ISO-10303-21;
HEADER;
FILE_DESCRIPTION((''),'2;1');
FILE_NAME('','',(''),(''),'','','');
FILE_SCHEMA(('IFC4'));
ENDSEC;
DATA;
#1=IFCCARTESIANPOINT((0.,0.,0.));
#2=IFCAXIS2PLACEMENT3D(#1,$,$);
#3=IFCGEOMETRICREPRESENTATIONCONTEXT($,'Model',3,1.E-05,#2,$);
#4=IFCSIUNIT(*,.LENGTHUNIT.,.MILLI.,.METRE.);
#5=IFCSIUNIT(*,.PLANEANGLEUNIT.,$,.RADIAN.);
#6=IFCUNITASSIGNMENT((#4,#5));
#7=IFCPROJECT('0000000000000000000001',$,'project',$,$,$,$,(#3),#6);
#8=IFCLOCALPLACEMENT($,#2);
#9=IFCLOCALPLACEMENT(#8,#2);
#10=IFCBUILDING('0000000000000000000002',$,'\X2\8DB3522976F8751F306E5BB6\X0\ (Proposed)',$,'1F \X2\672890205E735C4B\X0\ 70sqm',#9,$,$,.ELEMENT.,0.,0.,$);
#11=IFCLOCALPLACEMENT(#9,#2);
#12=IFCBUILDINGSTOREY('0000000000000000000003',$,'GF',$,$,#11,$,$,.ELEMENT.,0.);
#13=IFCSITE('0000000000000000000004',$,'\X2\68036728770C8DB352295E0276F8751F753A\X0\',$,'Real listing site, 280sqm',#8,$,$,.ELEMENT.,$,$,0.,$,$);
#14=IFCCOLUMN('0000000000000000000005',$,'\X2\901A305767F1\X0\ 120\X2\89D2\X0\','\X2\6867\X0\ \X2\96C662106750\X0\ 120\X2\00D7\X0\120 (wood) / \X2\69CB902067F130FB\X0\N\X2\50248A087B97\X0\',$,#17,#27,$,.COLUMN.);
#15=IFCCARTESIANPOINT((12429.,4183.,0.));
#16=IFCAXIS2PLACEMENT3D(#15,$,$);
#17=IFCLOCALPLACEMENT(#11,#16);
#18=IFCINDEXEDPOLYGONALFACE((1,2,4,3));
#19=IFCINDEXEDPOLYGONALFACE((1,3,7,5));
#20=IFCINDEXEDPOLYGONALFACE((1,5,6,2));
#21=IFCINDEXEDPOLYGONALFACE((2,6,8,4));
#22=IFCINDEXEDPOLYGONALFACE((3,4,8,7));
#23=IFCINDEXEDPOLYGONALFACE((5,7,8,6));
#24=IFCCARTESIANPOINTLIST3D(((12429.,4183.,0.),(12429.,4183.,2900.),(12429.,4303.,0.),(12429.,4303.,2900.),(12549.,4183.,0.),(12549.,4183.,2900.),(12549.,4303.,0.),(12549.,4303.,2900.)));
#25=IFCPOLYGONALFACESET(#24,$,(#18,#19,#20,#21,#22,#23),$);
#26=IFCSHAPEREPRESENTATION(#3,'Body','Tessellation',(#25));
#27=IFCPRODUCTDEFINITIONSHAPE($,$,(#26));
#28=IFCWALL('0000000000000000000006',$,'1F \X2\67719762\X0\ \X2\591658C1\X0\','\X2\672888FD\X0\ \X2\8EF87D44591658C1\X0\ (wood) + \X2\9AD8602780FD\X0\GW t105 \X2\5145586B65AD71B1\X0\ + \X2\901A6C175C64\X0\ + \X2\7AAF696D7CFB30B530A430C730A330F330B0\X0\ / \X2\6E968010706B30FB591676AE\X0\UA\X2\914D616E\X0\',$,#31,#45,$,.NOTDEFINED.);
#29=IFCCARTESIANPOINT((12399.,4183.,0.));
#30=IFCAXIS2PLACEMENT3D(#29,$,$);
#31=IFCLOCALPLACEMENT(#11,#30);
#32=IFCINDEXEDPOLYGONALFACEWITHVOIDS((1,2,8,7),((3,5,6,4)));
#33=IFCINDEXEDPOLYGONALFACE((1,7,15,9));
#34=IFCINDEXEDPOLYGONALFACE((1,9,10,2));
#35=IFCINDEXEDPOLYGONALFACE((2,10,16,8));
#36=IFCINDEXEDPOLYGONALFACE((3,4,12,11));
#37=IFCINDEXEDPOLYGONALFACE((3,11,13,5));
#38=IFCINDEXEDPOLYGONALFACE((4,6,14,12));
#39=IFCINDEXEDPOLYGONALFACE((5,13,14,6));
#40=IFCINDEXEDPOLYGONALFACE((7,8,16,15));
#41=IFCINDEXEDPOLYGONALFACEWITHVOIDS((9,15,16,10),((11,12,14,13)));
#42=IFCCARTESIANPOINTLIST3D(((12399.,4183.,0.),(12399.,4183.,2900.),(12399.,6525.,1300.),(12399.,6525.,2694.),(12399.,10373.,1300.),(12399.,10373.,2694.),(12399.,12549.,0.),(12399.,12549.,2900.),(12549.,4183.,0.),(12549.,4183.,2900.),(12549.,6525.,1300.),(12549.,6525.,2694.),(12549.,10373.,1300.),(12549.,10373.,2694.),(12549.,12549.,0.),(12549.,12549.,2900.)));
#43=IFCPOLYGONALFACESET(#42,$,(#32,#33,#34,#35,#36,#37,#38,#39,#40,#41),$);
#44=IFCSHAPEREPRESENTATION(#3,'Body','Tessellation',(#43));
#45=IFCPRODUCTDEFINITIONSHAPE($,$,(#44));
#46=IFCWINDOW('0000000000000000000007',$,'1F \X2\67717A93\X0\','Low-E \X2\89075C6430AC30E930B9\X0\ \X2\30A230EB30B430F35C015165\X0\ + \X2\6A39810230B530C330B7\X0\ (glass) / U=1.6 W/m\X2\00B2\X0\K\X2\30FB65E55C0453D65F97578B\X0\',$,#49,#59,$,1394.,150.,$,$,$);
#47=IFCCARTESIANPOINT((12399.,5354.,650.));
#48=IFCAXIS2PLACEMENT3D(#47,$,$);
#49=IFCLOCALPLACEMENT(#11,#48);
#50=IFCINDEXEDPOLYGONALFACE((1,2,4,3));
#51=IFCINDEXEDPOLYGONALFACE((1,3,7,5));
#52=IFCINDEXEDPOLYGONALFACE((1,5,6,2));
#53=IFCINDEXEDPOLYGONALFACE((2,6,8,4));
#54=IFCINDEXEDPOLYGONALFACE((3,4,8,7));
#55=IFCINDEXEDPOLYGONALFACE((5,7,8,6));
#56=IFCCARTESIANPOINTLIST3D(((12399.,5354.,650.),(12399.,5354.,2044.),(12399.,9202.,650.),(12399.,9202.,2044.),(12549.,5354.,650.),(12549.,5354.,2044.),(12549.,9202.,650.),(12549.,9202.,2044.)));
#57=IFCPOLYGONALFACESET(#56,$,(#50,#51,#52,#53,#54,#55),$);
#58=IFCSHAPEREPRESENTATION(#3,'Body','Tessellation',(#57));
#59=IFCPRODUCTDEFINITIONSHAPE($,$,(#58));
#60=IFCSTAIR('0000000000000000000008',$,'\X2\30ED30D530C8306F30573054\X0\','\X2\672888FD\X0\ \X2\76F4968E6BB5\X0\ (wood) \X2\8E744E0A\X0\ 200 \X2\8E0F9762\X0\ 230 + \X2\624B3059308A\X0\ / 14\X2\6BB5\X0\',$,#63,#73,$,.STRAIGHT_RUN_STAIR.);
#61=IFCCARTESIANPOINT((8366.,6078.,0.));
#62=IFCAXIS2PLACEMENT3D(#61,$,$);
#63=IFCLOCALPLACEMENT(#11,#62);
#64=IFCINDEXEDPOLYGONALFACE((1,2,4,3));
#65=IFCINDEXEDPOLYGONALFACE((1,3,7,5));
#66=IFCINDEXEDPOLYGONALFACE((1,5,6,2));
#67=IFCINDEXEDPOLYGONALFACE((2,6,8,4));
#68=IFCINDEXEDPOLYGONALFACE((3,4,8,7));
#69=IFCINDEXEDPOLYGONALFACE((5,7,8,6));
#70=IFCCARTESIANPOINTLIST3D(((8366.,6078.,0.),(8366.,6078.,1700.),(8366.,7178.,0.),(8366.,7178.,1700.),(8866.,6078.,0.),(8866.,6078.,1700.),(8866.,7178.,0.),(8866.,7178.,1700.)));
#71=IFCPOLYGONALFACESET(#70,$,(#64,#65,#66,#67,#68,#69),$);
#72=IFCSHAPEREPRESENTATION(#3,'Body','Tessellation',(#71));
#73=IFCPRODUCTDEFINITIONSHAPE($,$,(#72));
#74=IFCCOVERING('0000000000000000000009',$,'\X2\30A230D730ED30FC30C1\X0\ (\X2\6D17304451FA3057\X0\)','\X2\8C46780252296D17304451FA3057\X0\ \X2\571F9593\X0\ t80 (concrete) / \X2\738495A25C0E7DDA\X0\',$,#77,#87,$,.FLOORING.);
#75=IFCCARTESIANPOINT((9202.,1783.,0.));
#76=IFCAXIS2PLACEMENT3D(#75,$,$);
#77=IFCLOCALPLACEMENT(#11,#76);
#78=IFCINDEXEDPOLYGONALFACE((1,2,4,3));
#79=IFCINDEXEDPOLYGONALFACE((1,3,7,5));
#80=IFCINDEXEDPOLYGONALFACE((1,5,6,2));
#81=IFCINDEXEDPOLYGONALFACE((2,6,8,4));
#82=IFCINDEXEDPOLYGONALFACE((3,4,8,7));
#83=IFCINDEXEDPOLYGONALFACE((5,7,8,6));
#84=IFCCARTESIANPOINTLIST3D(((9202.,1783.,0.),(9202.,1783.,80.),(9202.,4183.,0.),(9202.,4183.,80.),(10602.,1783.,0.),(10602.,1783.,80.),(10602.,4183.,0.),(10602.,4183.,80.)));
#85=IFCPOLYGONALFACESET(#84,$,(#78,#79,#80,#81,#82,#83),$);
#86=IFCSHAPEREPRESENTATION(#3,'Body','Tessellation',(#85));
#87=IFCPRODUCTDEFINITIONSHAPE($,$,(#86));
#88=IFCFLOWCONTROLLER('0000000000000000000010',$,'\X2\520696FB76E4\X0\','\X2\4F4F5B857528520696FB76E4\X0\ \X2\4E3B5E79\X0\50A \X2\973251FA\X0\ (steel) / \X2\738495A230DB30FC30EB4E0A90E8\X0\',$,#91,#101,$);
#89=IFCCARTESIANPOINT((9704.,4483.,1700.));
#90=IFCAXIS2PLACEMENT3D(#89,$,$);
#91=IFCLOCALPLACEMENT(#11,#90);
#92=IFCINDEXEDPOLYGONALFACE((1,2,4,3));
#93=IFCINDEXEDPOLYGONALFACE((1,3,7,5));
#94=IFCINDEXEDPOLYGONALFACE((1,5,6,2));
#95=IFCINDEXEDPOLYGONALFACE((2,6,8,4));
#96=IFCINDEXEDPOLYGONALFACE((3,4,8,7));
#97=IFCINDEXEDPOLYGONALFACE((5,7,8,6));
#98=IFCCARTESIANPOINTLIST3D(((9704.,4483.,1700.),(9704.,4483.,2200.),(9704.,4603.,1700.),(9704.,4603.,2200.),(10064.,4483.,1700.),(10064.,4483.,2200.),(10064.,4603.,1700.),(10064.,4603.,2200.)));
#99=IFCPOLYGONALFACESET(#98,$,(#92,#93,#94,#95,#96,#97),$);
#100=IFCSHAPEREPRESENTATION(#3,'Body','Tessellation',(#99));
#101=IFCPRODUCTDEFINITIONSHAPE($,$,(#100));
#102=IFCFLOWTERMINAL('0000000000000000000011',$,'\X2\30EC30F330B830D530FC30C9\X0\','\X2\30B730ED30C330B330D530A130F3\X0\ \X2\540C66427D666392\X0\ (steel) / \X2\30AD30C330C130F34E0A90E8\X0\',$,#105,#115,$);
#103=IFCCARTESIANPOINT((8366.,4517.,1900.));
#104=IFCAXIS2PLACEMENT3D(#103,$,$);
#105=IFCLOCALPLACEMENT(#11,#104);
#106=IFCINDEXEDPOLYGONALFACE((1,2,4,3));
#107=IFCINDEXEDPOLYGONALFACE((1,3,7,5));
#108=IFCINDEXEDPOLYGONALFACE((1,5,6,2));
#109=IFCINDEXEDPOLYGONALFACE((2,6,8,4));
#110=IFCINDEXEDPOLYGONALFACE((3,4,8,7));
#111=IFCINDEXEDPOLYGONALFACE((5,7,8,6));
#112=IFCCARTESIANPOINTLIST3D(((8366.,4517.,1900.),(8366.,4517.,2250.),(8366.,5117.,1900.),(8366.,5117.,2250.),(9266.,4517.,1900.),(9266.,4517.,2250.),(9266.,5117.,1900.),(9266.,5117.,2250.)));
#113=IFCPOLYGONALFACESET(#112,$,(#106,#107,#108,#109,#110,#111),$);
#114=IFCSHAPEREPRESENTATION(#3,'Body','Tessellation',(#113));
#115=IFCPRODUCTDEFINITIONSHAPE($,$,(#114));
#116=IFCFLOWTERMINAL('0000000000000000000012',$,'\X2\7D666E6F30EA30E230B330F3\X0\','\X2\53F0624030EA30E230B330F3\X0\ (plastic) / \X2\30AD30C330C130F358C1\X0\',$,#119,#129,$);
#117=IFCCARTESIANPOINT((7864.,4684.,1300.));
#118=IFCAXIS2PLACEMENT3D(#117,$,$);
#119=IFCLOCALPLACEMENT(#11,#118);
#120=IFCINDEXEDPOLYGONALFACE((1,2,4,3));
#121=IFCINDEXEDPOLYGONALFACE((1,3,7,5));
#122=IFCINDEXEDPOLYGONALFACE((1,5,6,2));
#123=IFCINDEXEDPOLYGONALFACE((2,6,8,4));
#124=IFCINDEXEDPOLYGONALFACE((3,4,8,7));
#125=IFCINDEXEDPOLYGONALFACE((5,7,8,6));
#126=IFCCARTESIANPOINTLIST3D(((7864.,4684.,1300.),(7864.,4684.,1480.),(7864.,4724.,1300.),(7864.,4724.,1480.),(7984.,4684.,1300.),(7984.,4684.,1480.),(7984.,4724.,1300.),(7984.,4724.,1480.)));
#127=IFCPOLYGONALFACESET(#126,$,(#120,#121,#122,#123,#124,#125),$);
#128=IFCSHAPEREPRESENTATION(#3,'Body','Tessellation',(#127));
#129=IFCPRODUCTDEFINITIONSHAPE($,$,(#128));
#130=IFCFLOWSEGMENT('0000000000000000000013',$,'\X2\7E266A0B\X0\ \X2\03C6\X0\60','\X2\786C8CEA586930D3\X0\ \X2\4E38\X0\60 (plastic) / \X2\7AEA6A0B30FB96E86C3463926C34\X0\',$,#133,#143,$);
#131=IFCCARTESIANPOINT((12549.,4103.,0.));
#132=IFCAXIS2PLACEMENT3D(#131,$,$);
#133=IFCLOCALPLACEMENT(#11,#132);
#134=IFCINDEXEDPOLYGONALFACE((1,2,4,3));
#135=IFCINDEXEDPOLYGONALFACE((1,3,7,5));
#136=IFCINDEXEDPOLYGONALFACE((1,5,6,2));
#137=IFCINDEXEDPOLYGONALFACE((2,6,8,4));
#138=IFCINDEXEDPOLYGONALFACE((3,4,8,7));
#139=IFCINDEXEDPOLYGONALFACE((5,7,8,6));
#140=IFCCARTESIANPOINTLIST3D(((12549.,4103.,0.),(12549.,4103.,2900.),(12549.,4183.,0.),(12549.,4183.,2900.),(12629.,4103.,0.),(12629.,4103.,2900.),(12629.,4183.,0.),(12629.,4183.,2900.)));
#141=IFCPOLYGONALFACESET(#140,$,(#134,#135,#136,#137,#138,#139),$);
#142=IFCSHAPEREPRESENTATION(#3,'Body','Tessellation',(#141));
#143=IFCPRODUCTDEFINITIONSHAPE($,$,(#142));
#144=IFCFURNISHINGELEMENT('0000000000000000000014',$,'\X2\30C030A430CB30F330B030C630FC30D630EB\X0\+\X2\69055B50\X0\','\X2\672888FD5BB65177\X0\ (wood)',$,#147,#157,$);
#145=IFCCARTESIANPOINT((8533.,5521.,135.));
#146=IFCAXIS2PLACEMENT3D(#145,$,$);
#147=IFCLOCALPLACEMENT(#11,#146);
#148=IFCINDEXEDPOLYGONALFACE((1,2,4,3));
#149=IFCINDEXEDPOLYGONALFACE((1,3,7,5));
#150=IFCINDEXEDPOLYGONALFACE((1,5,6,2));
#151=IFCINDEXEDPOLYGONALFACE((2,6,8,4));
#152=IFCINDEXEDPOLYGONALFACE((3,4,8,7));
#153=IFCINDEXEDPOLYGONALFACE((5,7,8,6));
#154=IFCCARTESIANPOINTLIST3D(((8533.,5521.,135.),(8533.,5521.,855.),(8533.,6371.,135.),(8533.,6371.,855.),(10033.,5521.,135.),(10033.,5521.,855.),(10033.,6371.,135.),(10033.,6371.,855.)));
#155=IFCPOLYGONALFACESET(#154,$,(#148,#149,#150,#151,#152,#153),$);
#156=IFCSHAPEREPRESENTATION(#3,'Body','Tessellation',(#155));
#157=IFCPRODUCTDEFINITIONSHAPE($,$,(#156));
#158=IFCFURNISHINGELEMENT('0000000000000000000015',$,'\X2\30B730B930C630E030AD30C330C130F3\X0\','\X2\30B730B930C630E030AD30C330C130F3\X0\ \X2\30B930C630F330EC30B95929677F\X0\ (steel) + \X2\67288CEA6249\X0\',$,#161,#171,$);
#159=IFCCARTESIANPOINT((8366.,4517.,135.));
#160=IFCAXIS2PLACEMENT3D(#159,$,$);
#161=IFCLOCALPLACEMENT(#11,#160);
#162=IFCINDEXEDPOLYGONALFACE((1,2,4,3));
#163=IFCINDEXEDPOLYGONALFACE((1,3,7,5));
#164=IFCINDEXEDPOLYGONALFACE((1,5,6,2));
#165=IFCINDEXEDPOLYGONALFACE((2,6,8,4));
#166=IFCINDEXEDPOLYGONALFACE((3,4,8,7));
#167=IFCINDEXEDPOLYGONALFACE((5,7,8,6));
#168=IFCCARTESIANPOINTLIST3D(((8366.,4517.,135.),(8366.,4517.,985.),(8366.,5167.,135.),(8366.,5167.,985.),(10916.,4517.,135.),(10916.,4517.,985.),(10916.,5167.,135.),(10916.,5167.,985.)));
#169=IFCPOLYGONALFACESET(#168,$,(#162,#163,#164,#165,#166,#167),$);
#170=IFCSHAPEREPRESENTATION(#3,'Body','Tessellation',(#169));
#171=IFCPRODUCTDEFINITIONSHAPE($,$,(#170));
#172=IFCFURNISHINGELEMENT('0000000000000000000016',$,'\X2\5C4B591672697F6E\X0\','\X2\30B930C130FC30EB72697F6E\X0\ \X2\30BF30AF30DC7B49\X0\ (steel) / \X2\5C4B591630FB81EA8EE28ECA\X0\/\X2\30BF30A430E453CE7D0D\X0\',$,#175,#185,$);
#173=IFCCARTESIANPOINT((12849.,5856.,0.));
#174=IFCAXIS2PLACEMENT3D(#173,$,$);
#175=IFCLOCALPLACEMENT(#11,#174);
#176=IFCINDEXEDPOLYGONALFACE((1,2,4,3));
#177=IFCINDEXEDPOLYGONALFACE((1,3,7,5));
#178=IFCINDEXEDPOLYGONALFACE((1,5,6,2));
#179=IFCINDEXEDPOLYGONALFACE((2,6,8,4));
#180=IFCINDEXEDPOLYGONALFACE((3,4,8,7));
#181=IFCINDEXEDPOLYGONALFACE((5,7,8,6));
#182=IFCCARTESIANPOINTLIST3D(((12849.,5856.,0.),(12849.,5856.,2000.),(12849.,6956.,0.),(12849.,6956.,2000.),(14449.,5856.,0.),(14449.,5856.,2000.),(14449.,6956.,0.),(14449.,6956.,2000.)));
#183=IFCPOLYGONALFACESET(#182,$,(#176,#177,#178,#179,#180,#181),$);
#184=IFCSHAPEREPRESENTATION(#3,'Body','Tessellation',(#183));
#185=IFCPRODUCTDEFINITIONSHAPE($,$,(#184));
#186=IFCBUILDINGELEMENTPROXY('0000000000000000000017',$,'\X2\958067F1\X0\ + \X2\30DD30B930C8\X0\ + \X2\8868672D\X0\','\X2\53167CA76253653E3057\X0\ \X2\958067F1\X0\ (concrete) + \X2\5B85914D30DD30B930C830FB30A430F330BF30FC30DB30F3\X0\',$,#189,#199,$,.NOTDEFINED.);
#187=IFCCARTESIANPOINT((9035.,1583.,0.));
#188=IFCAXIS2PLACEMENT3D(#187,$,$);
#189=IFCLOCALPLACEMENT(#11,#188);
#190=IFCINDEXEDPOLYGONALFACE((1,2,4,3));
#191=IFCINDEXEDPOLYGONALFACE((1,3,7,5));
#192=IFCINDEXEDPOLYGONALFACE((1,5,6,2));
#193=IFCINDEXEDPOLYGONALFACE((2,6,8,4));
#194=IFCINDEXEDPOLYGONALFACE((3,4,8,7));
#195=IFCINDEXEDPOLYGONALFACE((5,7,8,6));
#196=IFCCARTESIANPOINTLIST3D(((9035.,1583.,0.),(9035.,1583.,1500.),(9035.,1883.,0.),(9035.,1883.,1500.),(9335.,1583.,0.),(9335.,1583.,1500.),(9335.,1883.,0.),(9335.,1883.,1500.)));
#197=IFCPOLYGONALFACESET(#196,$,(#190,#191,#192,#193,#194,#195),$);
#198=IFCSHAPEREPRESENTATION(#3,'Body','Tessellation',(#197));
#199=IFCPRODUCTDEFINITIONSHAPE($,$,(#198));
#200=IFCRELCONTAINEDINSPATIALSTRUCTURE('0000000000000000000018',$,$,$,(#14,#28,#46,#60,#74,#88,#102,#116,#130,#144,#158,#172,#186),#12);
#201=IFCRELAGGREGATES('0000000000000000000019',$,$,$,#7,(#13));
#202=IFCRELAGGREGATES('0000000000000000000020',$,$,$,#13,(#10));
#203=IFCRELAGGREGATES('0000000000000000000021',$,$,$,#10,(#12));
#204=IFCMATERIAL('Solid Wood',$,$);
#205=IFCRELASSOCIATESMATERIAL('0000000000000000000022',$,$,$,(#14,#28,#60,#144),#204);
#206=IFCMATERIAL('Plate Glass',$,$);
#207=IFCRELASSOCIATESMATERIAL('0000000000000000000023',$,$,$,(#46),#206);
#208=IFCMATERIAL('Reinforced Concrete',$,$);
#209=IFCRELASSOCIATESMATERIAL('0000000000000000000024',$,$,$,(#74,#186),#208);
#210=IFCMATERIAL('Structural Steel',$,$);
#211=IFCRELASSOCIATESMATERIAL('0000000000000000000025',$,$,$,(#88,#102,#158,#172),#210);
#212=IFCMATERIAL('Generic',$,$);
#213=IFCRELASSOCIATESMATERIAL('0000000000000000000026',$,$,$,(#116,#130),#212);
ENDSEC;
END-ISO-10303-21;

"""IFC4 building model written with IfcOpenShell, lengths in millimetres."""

from ifc_helpers import new_model, si_unit, frame, frame_2d, origin, place, context, project, spatial, rectangle, extrude, material, element, fill, save


model = new_model("IFC4")

# Units and contexts
model_context = context("Model", 3, precision=1e-05, world=origin())
ifc_project = project(units=[si_unit("LENGTHUNIT", "METRE", prefix="MILLI"), si_unit("PLANEANGLEUNIT", "RADIAN")], contexts=[model_context])

# Site, building, storey
site_placement = place(None, origin())
site = spatial("IfcSite", under=ifc_project, at=site_placement, Name="栃木県足利市相生町", ObjectType="Real listing site, 280sqm", CompositionType="ELEMENT", RefElevation=0.0)
building_placement = place(site_placement, origin())
building = spatial("IfcBuilding", under=site, at=building_placement, Name="足利相生の家 (Proposed)", ObjectType="1F 木造平屋 70sqm", CompositionType="ELEMENT", ElevationOfRefHeight=0.0, ElevationOfTerrain=0.0)
storey_placement = place(building_placement, origin())
storey = spatial("IfcBuildingStorey", under=building, at=storey_placement, Name="GF", CompositionType="ELEMENT", Elevation=0.0)

# Column
ifc_material_1 = material(Name="Solid Wood")
column_1_placement = place(storey_placement, frame((12429.0, 4183.0, 0.0)))
element("IfcColumn", 1, at=column_1_placement, inside=storey, material=ifc_material_1, Name="通し柱 120角", Description="桧 集成材 120×120 (wood) / 構造柱・N値計算", PredefinedType="COLUMN", context=model_context, shape_type="SweptSolid", body=[
    extrude(rectangle(XDim=120.0, YDim=120.0, at=frame_2d((60.0, 60.0))), frame((12429.0, 4183.0, 0.0)), (0.0, 0.0, 1.0), 2900.0),
])

# Wall, opening, window
wall_1_placement = place(storey_placement, frame((12399.0, 4183.0, 0.0)))
wall_1 = element("IfcWall", 2, at=wall_1_placement, inside=storey, material=ifc_material_1, Name="1F 東面 外壁", Description="木製 軸組外壁 (wood) + 高性能GW t105 充填断熱 + 通気層 + 窯業系サイディング / 準耐火・外皮UA配慮", PredefinedType="NOTDEFINED", context=model_context, shape_type="SweptSolid", body=[
    extrude(rectangle(XDim=150.0, YDim=8366.0, at=frame_2d((75.0, 4183.0))), frame((12399.0, 4183.0, 0.0)), (0.0, 0.0, 1.0), 2900.0),
])
opening_placement = place(storey_placement, frame((12399.0, 5354.0, 650.0)))
opening = element("IfcOpeningElement", 3, at=opening_placement, cuts=wall_1, PredefinedType="NOTDEFINED", context=model_context, shape_type="SweptSolid", body=[
    extrude(rectangle(XDim=150.0, YDim=3848.0, at=frame_2d((75.0, 1924.0))), frame((12399.0, 5354.0, 650.0)), (0.0, 0.0, 1.0), 1394.0),
])
ifc_material_2 = material(Name="Plate Glass")
window_placement = place(storey_placement, frame((12399.0, 5354.0, 650.0)))
window = element("IfcWindow", 4, at=window_placement, inside=storey, material=ifc_material_2, Name="1F 東窓", Description="Low-E 複層ガラス アルゴン封入 + 樹脂サッシ (glass) / U=1.6 W/m²K・日射取得型", OverallHeight=1394.0, OverallWidth=150.0, context=model_context, shape_type="SweptSolid", body=[
    extrude(rectangle(XDim=150.0, YDim=3848.0, at=frame_2d((75.0, 1924.0))), frame((12399.0, 5354.0, 650.0)), (0.0, 0.0, 1.0), 1394.0),
])
fill(opening, window)

# Stair
stair_placement = place(storey_placement, frame((8366.0, 6078.0, 0.0)))
element("IfcStair", 5, at=stair_placement, inside=storey, material=ifc_material_1, Name="ロフトはしご", Description="木製 直階段 (wood) 蹴上 200 踏面 230 + 手すり / 14段", PredefinedType="STRAIGHT_RUN_STAIR", context=model_context, shape_type="SweptSolid", body=[
    extrude(rectangle(XDim=500.0, YDim=1100.0, at=frame_2d((250.0, 550.0))), frame((8366.0, 6078.0, 0.0)), (0.0, 0.0, 1.0), 1700.0),
])

# Covering
ifc_material_3 = material(Name="Reinforced Concrete")
covering_placement = place(storey_placement, frame((9202.0, 1783.0, 0.0)))
element("IfcCovering", 6, at=covering_placement, inside=storey, material=ifc_material_3, Name="アプローチ (洗い出し)", Description="豆砂利洗い出し 土間 t80 (concrete) / 玄関導線", PredefinedType="FLOORING", context=model_context, shape_type="SweptSolid", body=[
    extrude(rectangle(XDim=1400.0, YDim=2400.0, at=frame_2d((700.0, 1200.0))), frame((9202.0, 1783.0, 0.0)), (0.0, 0.0, 1.0), 80.0),
])

# Flow controller
ifc_material_4 = material(Name="Structural Steel")
flow_controller_placement = place(storey_placement, frame((9704.0, 4483.0, 1700.0)))
element("IfcFlowController", 7, at=flow_controller_placement, inside=storey, material=ifc_material_4, Name="分電盤", Description="住宅用分電盤 主幹50A 露出 (steel) / 玄関ホール上部", context=model_context, shape_type="SweptSolid", body=[
    extrude(rectangle(XDim=360.0, YDim=120.0, at=frame_2d((180.0, 60.0))), frame((9704.0, 4483.0, 1700.0)), (0.0, 0.0, 1.0), 500.0),
])

# Flow terminals
flow_terminal_1_placement = place(storey_placement, frame((8366.0, 4517.0, 1900.0)))
element("IfcFlowTerminal", 8, at=flow_terminal_1_placement, inside=storey, material=ifc_material_4, Name="レンジフード", Description="シロッコファン 同時給排 (steel) / キッチン上部", context=model_context, shape_type="SweptSolid", body=[
    extrude(rectangle(XDim=900.0, YDim=600.0, at=frame_2d((450.0, 300.0))), frame((8366.0, 4517.0, 1900.0)), (0.0, 0.0, 1.0), 350.0),
])
ifc_material_5 = material(Name="Generic")
flow_terminal_2_placement = place(storey_placement, frame((7864.0, 4684.0, 1300.0)))
element("IfcFlowTerminal", 9, at=flow_terminal_2_placement, inside=storey, material=ifc_material_5, Name="給湯リモコン", Description="台所リモコン (plastic) / キッチン壁", context=model_context, shape_type="SweptSolid", body=[
    extrude(rectangle(XDim=120.0, YDim=40.0, at=frame_2d((60.0, 20.0))), frame((7864.0, 4684.0, 1300.0)), (0.0, 0.0, 1.0), 180.0),
])

# Flow segment
flow_segment_placement = place(storey_placement, frame((12549.0, 4103.0, 0.0)))
element("IfcFlowSegment", 10, at=flow_segment_placement, inside=storey, material=ifc_material_5, Name="縦樋 φ60", Description="硬質塩ビ 丸60 (plastic) / 竪樋・雨水排水", context=model_context, shape_type="SweptSolid", body=[
    extrude(rectangle(XDim=80.0, YDim=80.0, at=frame_2d((40.0, 40.0))), frame((12549.0, 4103.0, 0.0)), (0.0, 0.0, 1.0), 2900.0),
])

# Furnishing elements
furnishing_1_placement = place(storey_placement, frame((8533.0, 5521.0, 135.0)))
element("IfcFurnishingElement", 11, at=furnishing_1_placement, inside=storey, material=ifc_material_1, Name="ダイニングテーブル+椅子", Description="木製家具 (wood)", context=model_context, shape_type="SweptSolid", body=[
    extrude(rectangle(XDim=1500.0, YDim=850.0, at=frame_2d((750.0, 425.0))), frame((8533.0, 5521.0, 135.0)), (0.0, 0.0, 1.0), 720.0),
])
furnishing_2_placement = place(storey_placement, frame((8366.0, 4517.0, 135.0)))
element("IfcFurnishingElement", 12, at=furnishing_2_placement, inside=storey, material=ifc_material_4, Name="システムキッチン", Description="システムキッチン ステンレス天板 (steel) + 木質扉", context=model_context, shape_type="SweptSolid", body=[
    extrude(rectangle(XDim=2550.0, YDim=650.0, at=frame_2d((1275.0, 325.0))), frame((8366.0, 4517.0, 135.0)), (0.0, 0.0, 1.0), 850.0),
])
furnishing_3_placement = place(storey_placement, frame((12849.0, 5856.0, 0.0)))
element("IfcFurnishingElement", 13, at=furnishing_3_placement, inside=storey, material=ifc_material_4, Name="屋外物置", Description="スチール物置 タクボ等 (steel) / 屋外・自転車/タイヤ収納", context=model_context, shape_type="SweptSolid", body=[
    extrude(rectangle(XDim=1600.0, YDim=1100.0, at=frame_2d((800.0, 550.0))), frame((12849.0, 5856.0, 0.0)), (0.0, 0.0, 1.0), 2000.0),
])

# Building element proxy
proxy_placement = place(storey_placement, frame((9035.0, 1583.0, 0.0)))
element("IfcBuildingElementProxy", 14, at=proxy_placement, inside=storey, material=ifc_material_3, Name="門柱 + ポスト + 表札", Description="化粧打放し 門柱 (concrete) + 宅配ポスト・インターホン", PredefinedType="NOTDEFINED", context=model_context, shape_type="SweptSolid", body=[
    extrude(rectangle(XDim=300.0, YDim=300.0, at=frame_2d((150.0, 150.0))), frame((9035.0, 1583.0, 0.0)), (0.0, 0.0, 1.0), 1500.0),
])

save(model, "model.ifc")
